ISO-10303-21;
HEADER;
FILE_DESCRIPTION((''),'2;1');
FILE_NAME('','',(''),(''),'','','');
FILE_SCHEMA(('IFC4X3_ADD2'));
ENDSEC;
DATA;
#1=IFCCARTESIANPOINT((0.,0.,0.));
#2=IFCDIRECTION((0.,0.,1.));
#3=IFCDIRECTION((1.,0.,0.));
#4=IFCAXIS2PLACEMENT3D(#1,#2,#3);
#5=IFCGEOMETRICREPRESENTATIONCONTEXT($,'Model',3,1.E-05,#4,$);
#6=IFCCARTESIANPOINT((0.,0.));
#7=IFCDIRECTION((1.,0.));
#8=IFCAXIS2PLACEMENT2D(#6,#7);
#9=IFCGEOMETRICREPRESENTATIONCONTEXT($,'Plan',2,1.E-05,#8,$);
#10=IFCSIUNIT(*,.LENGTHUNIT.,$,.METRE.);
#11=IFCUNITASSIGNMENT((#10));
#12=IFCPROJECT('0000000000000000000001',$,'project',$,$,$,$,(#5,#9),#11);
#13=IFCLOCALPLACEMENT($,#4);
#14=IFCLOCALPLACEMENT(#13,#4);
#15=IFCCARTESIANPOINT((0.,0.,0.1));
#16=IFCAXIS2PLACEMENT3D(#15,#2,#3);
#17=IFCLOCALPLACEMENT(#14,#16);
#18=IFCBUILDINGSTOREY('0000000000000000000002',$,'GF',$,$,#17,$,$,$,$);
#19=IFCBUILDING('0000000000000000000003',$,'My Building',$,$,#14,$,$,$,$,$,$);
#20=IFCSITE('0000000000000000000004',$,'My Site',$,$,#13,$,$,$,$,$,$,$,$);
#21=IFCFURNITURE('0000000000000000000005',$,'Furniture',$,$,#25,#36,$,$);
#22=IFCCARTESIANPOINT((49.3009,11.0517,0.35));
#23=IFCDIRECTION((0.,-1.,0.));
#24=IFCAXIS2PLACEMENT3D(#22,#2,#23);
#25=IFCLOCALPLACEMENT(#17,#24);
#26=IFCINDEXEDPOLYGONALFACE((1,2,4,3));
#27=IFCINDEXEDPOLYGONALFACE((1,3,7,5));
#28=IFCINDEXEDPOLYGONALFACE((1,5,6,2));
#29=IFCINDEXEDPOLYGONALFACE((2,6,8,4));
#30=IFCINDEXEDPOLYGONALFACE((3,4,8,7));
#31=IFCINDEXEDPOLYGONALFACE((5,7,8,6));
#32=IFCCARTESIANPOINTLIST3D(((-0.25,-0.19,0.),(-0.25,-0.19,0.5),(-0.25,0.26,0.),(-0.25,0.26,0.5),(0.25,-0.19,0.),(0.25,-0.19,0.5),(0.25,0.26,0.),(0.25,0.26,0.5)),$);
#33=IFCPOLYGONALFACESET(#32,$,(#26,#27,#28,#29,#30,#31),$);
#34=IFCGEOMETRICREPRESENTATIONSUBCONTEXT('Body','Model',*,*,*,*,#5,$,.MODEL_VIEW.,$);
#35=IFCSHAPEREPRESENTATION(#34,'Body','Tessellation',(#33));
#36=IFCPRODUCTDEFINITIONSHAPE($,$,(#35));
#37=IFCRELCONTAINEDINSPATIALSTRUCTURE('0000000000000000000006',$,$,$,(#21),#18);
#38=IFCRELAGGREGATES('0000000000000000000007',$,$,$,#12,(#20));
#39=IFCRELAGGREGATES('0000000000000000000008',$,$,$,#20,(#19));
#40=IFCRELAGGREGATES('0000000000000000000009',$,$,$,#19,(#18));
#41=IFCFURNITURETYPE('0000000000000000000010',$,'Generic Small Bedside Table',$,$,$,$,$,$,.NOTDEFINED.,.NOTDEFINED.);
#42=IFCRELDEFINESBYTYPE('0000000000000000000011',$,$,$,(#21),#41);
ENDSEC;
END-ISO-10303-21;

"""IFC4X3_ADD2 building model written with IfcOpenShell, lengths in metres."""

from ifc_helpers import new_model, entity, si_unit, frame, origin_with_axes, origin_2d_with_axis, place, context, subcontext, project, spatial, line, indexed_curve, outline, extrude, shape, source, transform, mapped, type_object, type_shapes, element, save


model = new_model("IFC4X3_ADD2")

# Units and contexts
model_context = context("Model", 3, precision=1e-05, world=origin_with_axes())
plan_context = context("Plan", 2, precision=1e-05, world=origin_2d_with_axis())
body_context_1 = subcontext(model_context, "Body", "Model", "MODEL_VIEW")
body_context_2 = subcontext(plan_context, "Body", "Plan", "PLAN_VIEW")
ifc_project = project(units=[si_unit("LENGTHUNIT", "METRE")], contexts=[model_context, plan_context])

# Site, building, storey
site_placement = place(None, origin_with_axes())
site = spatial("IfcSite", under=ifc_project, at=site_placement, Name="My Site")
building_placement = place(site_placement, origin_with_axes())
building = spatial("IfcBuilding", under=site, at=building_placement, Name="My Building")
storey_placement = place(building_placement, frame((0.0, 0.0, 0.1), z_axis=(0.0, 0.0, 1.0), x_axis=(1.0, 0.0, 0.0)))
storey = spatial("IfcBuildingStorey", under=building, at=storey_placement, Name="GF")

# Furniture
furniture_type_1 = type_object("IfcFurnitureType", Name="Generic Small Bedside Table", AssemblyPlace="NOTDEFINED", PredefinedType="NOTDEFINED")
shared_shape_1 = source(origin_with_axes(), body_context_1, "Body", "SweptSolid", [
    extrude(outline(indexed_curve([(0.5, 0.45), (0.5, 0.0), (0.0, 0.0), (0.0, 0.45)], segments=[line(4, 1), line(1, 2), line(2, 3), line(3, 4)], self_intersect=False)), frame((-0.25, -0.19, 0.0), z_axis=(0.0, 0.0, 1.0), x_axis=(1.0, 0.0, 0.0)), (0.0, 0.0, 1.0), 0.5),
])
shared_shape_2 = source(origin_with_axes(), body_context_2, "Body", "Annotation2D", [
    entity("IfcGeometricCurveSet", [entity("IfcIndexedPolyCurve", entity("IfcCartesianPointList2D", [[-0.25, -0.19], [0.25, -0.19], [0.25, 0.26], [-0.25, 0.26]]), [entity("IfcLineIndex", [1, 2]), entity("IfcLineIndex", [2, 3]), entity("IfcLineIndex", [3, 4]), entity("IfcLineIndex", [4, 1])])]),
])
type_shapes(furniture_type_1, [shared_shape_1, shared_shape_2])
furniture_1_placement = place(storey_placement, frame((49.3009, 11.0517, 0.35), z_axis=(0.0, 0.0, 1.0), x_axis=(0.0, -1.0, 0.0)))
element("IfcFurniture", 1, at=furniture_1_placement, inside=storey, type_object=furniture_type_1, Name="Furniture", shapes=[
    shape(body_context_1, "Body", "MappedRepresentation", [mapped(shared_shape_1, transform((0.0, 0.0, 0.0), x_axis=(1.0, 0.0, 0.0), y_axis=(0.0, 1.0, 0.0), z_axis=(0.0, 0.0, 1.0), scale=1.0))]),
    shape(body_context_2, "Body", "MappedRepresentation", [mapped(shared_shape_2, transform((0.0, 0.0, 0.0), x_axis=(1.0, 0.0, 0.0), y_axis=(0.0, 1.0, 0.0), z_axis=(0.0, 0.0, 1.0), scale=1.0))]),
])

save(model, "model.ifc")
